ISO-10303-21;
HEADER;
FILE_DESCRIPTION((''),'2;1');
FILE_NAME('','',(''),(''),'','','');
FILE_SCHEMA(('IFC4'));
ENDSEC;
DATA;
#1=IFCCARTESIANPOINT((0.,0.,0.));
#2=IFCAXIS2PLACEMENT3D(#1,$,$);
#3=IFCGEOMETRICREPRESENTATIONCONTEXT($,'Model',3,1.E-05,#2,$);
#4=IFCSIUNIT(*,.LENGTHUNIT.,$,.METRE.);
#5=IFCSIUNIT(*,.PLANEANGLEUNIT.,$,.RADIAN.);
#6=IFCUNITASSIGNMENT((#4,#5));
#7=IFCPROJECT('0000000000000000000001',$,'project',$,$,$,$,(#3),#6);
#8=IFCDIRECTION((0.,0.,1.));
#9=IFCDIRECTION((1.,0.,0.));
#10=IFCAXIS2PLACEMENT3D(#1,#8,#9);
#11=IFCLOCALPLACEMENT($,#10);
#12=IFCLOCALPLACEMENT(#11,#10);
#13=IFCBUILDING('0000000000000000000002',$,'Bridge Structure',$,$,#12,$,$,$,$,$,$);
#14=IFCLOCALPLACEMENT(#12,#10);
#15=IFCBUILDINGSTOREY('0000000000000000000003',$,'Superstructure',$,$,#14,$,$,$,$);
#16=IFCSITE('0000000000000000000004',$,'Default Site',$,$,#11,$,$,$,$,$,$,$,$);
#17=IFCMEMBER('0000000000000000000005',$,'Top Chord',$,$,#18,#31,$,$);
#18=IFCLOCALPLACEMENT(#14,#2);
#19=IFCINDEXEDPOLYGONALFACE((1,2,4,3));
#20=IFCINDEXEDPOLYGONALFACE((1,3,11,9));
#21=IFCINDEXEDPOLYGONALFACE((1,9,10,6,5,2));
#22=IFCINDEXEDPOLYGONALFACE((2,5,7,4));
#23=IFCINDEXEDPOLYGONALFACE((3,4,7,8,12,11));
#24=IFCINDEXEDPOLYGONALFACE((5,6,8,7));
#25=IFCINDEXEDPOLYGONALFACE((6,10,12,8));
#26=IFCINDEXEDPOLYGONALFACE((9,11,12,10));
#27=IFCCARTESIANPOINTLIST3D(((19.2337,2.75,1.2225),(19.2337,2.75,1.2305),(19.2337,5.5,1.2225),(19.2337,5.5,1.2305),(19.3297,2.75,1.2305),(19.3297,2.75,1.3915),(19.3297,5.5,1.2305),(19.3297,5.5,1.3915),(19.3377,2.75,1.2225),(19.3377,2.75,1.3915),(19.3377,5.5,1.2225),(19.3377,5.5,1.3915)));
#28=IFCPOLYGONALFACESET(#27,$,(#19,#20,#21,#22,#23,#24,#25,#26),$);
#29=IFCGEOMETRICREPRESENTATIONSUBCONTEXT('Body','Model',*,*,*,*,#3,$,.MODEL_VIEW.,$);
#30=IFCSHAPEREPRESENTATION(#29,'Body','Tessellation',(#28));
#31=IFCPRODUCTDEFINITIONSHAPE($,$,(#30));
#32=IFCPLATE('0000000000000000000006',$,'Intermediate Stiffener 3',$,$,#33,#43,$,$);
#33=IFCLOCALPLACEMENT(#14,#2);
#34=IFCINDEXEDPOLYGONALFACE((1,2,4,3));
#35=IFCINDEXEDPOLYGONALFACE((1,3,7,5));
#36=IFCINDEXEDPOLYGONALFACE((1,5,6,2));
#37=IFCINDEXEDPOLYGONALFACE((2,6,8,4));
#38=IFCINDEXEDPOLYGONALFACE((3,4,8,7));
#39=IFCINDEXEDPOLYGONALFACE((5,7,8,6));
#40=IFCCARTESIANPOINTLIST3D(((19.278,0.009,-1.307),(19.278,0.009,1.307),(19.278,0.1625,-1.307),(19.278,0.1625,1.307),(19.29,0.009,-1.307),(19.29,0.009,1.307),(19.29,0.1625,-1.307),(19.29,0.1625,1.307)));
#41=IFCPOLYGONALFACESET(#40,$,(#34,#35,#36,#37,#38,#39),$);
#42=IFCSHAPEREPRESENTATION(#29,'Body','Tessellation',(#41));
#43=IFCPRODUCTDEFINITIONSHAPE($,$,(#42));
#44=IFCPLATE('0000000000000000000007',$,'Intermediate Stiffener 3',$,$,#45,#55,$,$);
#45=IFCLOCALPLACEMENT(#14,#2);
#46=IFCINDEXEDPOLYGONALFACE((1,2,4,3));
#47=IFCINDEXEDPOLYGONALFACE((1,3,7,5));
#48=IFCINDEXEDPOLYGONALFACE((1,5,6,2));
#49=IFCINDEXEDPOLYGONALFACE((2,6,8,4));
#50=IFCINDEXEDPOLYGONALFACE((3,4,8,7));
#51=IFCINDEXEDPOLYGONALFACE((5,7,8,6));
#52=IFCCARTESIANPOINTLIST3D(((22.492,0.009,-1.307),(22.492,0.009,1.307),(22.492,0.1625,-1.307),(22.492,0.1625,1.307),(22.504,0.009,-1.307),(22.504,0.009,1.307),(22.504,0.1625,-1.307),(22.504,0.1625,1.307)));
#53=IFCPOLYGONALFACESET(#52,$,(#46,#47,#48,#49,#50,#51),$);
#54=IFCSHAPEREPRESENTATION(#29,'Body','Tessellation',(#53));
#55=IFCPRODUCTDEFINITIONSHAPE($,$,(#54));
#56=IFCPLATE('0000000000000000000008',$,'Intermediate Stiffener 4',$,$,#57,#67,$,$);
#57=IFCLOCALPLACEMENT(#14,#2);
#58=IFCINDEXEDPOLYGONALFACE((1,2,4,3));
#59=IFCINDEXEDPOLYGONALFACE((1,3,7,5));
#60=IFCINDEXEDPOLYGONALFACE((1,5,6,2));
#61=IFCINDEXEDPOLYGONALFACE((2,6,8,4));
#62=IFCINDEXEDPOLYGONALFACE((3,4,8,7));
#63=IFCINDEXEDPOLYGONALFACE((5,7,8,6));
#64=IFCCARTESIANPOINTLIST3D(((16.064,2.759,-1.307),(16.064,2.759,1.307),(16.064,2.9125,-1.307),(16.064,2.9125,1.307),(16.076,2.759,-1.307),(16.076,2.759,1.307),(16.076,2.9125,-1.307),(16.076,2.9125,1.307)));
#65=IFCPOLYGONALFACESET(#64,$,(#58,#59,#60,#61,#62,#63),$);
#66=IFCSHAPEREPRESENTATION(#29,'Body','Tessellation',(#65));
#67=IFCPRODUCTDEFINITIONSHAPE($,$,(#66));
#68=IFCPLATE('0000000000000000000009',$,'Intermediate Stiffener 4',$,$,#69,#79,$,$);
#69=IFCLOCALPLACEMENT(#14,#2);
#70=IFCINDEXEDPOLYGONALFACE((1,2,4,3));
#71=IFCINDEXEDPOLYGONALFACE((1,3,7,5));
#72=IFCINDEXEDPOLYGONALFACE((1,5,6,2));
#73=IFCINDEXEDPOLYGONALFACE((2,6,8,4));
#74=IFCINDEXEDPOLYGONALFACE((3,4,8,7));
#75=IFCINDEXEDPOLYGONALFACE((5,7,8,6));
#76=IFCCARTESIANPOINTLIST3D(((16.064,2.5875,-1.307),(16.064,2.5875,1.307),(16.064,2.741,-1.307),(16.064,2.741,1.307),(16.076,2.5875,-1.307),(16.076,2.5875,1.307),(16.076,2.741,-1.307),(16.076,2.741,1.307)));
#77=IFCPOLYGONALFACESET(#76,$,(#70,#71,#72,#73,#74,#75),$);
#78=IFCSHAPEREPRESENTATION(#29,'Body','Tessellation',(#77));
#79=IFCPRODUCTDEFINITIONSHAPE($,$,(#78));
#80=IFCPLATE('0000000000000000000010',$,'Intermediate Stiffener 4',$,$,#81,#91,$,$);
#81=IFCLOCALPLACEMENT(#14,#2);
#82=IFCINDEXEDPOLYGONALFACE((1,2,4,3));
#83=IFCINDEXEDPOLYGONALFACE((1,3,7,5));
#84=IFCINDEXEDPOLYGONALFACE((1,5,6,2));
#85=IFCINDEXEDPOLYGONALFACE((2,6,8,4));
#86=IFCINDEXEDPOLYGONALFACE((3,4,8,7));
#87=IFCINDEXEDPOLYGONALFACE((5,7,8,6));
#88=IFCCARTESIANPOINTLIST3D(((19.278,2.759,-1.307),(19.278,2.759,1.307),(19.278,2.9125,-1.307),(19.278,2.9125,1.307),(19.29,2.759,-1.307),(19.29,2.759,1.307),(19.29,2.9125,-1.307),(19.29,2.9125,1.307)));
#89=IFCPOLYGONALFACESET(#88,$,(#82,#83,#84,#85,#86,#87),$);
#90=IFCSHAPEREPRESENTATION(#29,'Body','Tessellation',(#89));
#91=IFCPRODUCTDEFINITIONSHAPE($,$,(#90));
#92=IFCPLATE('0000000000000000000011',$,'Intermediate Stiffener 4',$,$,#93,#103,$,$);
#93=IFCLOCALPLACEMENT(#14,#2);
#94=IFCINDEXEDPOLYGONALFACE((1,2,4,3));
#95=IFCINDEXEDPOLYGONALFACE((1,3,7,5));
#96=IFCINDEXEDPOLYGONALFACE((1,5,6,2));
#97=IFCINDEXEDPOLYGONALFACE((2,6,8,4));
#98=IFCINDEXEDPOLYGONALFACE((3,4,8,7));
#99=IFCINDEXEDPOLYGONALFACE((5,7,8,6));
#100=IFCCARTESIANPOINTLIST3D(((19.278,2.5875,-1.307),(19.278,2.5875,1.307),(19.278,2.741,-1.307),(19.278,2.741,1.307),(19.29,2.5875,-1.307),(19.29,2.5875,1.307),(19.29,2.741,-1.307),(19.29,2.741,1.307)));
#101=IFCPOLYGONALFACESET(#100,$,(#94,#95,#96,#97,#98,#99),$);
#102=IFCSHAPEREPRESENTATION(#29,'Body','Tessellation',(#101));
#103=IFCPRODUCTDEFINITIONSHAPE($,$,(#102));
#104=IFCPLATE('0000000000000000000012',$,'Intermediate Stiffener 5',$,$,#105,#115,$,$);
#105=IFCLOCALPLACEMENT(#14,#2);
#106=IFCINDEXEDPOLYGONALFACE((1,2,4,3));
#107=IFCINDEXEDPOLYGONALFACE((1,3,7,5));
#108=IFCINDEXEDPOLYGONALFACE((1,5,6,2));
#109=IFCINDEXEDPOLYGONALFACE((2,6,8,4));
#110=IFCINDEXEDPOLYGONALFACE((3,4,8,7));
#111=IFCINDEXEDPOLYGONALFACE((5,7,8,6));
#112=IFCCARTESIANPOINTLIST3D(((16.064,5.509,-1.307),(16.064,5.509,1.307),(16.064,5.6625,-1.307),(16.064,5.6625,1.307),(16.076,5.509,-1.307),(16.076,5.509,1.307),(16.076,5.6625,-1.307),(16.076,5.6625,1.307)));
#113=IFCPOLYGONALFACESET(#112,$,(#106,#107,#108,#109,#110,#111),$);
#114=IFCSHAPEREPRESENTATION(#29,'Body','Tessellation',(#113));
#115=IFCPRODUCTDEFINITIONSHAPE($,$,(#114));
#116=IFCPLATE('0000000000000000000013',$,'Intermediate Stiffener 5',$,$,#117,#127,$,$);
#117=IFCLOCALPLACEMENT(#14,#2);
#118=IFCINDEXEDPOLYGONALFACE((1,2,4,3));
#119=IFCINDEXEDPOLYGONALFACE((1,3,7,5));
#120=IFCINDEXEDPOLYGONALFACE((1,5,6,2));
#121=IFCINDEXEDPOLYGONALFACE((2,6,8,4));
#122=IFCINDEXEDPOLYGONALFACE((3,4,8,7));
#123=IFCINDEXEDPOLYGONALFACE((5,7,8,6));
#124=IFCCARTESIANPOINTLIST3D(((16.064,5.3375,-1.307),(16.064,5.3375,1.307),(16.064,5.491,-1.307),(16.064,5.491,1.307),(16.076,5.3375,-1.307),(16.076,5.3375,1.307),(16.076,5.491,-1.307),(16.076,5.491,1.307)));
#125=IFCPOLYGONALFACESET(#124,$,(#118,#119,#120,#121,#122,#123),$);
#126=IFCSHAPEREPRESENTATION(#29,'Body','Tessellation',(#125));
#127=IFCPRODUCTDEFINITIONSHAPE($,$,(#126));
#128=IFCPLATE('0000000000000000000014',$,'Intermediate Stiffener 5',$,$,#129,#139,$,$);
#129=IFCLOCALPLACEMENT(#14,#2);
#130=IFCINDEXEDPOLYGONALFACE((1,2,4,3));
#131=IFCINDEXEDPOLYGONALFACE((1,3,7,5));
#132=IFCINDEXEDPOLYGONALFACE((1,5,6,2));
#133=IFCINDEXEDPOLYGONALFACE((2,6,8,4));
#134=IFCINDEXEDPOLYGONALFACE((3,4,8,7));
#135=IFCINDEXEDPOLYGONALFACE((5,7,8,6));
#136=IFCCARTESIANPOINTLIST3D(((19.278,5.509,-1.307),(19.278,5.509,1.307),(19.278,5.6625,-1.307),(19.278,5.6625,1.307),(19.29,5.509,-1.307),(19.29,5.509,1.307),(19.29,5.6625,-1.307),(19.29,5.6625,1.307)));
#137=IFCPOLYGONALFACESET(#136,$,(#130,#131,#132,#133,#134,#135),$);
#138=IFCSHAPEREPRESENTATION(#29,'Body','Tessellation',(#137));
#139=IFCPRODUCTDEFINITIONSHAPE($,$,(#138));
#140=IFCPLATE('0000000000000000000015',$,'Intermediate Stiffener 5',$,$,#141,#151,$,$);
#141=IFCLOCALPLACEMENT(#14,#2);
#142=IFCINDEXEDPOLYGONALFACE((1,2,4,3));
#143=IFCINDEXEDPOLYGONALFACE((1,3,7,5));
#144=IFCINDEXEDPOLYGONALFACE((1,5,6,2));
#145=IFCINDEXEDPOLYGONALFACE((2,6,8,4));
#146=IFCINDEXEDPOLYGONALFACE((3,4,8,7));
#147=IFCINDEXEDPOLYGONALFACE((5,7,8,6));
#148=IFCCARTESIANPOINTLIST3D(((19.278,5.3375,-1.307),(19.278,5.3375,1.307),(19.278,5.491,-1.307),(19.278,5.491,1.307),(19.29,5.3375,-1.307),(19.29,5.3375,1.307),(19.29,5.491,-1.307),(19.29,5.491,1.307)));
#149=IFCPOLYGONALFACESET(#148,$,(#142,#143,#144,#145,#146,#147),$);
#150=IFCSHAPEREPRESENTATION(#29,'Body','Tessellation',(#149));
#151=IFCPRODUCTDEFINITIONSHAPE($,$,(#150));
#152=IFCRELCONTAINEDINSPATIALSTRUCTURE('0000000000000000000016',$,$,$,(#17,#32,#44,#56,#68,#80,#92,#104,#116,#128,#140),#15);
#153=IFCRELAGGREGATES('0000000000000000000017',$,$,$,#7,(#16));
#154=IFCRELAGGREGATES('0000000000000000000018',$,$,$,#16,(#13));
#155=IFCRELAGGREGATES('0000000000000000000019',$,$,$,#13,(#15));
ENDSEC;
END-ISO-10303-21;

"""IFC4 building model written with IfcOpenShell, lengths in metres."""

from ifc_helpers import new_model, si_unit, frame, origin, origin_with_axes, origin_2d_with_axis, place, context, subcontext, project, spatial, rectangle, l_section, extrude, element, save


model = new_model("IFC4")

# Units and contexts
model_context = context("Model", 3, precision=1e-05, world=origin())
body_context = subcontext(model_context, "Body", "Model", "MODEL_VIEW")
ifc_project = project(units=[si_unit("LENGTHUNIT", "METRE"), si_unit("PLANEANGLEUNIT", "RADIAN")], contexts=[model_context])

# Site, building, storey
site_placement = place(None, origin_with_axes())
site = spatial("IfcSite", under=ifc_project, at=site_placement, Name="Default Site")
building_placement = place(site_placement, origin_with_axes())
building = spatial("IfcBuilding", under=site, at=building_placement, Name="Bridge Structure")
storey_placement = place(building_placement, origin_with_axes())
storey = spatial("IfcBuildingStorey", under=building, at=storey_placement, Name="Superstructure")

# Member
for number, where, z_axis, x_axis, name in (
    (1, (19.2857, 2.75, 1.307), (0.0, 1.0, 0.0), (-1.0, 0.0, 0.0), "Top Chord"),
):
    element("IfcMember", number, at=place(storey_placement, frame(where, z_axis=z_axis, x_axis=x_axis)), inside=storey, Name=name, context=body_context, shape_type="SweptSolid", body=[
        extrude(l_section(Depth=0.169, Width=0.104, Thickness=0.008, at=origin_2d_with_axis()), origin_with_axes(), (0.0, 0.0, 1.0), 2.75),
    ])

# Plates
for number, where, z_axis, x_axis, name in (
    (2, (19.284, 0.0858, -1.307), (0.0, 0.0, 1.0), (1.0, 0.0, 0.0), "Intermediate Stiffener 3"),
    (3, (22.498, 0.0858, -1.307), (0.0, 0.0, 1.0), (1.0, 0.0, 0.0), "Intermediate Stiffener 3"),
    (4, (16.07, 2.8357, -1.307), (0.0, 0.0, 1.0), (1.0, 0.0, 0.0), "Intermediate Stiffener 4"),
    (5, (16.07, 2.6643, -1.307), (0.0, 0.0, 1.0), (1.0, 0.0, 0.0), "Intermediate Stiffener 4"),
    (6, (19.284, 2.8357, -1.307), (0.0, 0.0, 1.0), (1.0, 0.0, 0.0), "Intermediate Stiffener 4"),
    (7, (19.284, 2.6643, -1.307), (0.0, 0.0, 1.0), (1.0, 0.0, 0.0), "Intermediate Stiffener 4"),
    (8, (16.07, 5.5857, -1.307), (0.0, 0.0, 1.0), (1.0, 0.0, 0.0), "Intermediate Stiffener 5"),
    (9, (16.07, 5.4143, -1.307), (0.0, 0.0, 1.0), (1.0, 0.0, 0.0), "Intermediate Stiffener 5"),
    (10, (19.284, 5.5857, -1.307), (0.0, 0.0, 1.0), (1.0, 0.0, 0.0), "Intermediate Stiffener 5"),
    (11, (19.284, 5.4143, -1.307), (0.0, 0.0, 1.0), (1.0, 0.0, 0.0), "Intermediate Stiffener 5"),
):
    element("IfcPlate", number, at=place(storey_placement, frame(where, z_axis=z_axis, x_axis=x_axis)), inside=storey, Name=name, context=body_context, shape_type="SweptSolid", body=[
        extrude(rectangle(XDim=0.012, YDim=0.1535, at=origin_2d_with_axis()), origin_with_axes(), (0.0, 0.0, 1.0), 2.614),
    ])

save(model, "model.ifc")
